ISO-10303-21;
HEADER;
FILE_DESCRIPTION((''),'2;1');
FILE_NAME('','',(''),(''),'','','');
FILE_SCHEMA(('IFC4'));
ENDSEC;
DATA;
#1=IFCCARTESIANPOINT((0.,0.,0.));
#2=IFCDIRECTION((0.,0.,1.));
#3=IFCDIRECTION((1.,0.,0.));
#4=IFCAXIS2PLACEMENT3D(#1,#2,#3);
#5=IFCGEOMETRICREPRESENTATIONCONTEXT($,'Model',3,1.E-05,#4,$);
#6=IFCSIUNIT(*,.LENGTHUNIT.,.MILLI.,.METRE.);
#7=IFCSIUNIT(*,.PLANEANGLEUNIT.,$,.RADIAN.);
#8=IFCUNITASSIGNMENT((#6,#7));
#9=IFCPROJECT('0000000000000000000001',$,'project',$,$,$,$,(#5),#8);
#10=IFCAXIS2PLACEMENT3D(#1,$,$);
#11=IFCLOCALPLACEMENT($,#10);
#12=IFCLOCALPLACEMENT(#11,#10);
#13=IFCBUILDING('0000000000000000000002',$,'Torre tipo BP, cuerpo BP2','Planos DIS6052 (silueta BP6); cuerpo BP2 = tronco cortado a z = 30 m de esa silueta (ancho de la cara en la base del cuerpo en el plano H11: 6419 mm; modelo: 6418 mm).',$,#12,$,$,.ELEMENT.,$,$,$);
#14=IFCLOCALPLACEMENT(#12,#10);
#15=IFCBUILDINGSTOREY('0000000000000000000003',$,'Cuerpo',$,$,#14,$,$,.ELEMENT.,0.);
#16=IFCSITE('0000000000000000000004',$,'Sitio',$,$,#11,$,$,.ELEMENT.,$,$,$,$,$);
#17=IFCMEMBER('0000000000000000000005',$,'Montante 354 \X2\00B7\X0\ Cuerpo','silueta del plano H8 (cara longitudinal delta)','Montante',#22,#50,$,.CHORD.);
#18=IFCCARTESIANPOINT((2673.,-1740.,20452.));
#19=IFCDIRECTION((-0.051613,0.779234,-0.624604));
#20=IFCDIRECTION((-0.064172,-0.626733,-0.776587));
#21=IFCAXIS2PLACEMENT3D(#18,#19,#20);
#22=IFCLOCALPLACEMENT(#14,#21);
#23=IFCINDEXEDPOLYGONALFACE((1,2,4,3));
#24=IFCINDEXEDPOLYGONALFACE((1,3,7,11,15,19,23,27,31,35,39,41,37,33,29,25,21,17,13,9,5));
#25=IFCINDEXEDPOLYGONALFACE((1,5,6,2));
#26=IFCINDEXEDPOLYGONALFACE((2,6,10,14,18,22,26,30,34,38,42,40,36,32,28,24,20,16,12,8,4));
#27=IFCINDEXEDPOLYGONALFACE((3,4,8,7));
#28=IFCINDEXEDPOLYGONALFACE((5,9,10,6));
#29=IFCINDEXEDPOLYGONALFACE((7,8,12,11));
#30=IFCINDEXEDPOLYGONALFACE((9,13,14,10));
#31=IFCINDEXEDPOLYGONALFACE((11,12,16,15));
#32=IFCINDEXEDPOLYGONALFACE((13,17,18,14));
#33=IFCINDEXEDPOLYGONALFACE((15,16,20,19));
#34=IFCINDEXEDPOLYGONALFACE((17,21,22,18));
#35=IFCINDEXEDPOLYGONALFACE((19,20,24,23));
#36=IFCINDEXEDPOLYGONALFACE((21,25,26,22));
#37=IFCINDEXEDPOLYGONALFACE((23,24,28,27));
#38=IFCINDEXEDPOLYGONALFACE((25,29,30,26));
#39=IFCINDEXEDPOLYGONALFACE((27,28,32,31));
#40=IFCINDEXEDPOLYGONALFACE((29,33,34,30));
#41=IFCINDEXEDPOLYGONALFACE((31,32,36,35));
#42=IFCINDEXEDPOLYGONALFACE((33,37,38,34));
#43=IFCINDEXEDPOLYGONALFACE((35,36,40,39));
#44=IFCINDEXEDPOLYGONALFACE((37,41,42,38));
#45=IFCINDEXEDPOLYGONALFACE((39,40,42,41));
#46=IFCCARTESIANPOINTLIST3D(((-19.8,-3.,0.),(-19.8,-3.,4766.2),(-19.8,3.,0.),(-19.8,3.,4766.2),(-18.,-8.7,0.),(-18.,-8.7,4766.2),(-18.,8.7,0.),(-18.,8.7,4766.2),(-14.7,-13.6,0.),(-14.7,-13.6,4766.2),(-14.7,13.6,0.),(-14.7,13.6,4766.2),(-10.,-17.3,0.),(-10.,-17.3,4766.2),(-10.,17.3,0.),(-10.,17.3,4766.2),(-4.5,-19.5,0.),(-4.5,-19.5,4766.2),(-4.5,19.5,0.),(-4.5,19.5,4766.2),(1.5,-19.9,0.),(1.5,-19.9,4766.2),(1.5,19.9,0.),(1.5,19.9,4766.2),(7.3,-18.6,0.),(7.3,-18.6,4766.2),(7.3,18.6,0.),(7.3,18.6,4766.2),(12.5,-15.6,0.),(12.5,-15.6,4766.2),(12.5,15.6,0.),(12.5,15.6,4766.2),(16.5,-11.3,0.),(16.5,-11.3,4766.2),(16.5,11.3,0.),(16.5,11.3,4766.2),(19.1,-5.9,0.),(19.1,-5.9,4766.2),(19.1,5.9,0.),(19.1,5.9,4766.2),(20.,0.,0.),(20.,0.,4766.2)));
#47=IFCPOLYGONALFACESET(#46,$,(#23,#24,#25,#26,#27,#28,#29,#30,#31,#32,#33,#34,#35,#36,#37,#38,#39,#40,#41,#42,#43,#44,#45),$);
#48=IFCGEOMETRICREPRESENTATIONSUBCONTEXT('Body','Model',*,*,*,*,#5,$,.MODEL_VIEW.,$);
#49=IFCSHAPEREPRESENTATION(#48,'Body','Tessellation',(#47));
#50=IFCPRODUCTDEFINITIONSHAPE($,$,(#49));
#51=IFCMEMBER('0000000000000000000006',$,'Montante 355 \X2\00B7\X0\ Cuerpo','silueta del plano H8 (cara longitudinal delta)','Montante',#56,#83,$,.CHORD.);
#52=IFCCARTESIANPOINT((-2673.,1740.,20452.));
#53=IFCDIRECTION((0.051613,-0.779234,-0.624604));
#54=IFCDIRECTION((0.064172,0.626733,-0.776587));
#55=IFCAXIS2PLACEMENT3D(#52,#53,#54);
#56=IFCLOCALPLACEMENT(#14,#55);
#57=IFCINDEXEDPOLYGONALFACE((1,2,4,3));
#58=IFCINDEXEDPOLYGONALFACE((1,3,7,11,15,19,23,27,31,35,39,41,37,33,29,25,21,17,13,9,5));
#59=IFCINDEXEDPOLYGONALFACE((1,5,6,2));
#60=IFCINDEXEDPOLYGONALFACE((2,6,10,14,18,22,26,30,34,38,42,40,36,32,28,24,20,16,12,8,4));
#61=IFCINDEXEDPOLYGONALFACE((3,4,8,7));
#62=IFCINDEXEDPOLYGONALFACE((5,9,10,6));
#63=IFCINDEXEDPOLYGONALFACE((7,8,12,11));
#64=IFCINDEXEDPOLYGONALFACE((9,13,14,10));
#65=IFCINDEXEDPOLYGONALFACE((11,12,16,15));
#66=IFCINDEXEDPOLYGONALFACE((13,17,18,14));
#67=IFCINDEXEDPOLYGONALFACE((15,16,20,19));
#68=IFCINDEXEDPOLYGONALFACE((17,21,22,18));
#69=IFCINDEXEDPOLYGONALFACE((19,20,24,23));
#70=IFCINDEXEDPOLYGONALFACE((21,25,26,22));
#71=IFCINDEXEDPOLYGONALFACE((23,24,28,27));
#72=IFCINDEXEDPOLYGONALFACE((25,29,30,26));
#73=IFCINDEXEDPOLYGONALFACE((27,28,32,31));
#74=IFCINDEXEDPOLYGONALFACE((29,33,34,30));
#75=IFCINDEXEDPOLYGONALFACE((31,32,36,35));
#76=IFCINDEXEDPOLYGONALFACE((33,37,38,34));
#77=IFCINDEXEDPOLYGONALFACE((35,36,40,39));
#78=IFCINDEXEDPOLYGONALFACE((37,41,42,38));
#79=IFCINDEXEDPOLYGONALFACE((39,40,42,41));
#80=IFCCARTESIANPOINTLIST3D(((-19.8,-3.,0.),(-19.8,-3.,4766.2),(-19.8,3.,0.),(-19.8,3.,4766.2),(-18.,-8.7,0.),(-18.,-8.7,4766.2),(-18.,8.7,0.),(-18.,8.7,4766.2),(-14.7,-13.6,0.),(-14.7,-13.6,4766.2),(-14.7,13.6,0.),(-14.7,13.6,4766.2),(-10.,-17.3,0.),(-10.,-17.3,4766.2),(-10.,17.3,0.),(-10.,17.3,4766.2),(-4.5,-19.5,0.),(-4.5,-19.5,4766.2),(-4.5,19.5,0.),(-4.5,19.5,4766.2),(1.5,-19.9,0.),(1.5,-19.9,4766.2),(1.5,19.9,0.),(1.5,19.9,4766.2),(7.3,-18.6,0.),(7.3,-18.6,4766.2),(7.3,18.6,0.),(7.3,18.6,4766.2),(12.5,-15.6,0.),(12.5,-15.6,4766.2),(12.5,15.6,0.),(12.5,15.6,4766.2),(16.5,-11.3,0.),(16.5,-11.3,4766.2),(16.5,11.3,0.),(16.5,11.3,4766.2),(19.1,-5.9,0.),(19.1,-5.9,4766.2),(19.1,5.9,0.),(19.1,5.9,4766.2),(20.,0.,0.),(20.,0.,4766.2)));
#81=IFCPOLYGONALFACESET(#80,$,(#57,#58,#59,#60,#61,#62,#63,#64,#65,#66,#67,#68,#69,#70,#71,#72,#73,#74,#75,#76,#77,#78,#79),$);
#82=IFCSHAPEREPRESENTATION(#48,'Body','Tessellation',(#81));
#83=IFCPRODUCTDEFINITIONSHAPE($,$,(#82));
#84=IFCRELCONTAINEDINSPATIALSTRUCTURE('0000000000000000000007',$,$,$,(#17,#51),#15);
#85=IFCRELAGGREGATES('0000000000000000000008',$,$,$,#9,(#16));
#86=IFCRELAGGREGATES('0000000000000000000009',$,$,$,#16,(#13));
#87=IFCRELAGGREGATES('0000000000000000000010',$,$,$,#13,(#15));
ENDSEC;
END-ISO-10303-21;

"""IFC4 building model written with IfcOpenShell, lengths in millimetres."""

from ifc_helpers import new_model, si_unit, frame, origin, origin_with_axes, place, context, subcontext, project, spatial, circle, extrude, element, save


model = new_model("IFC4")

# Units and contexts
model_context = context("Model", 3, precision=1e-05, world=origin_with_axes())
body_context = subcontext(model_context, "Body", "Model", "MODEL_VIEW")
ifc_project = project(units=[si_unit("LENGTHUNIT", "METRE", prefix="MILLI"), si_unit("PLANEANGLEUNIT", "RADIAN")], contexts=[model_context])

# Site, building, storey
site_placement = place(None, origin())
site = spatial("IfcSite", under=ifc_project, at=site_placement, Name="Sitio", CompositionType="ELEMENT")
building_placement = place(site_placement, origin())
building = spatial("IfcBuilding", under=site, at=building_placement, Name="Torre tipo BP, cuerpo BP2", Description="Planos DIS6052 (silueta BP6); cuerpo BP2 = tronco cortado a z = 30 m de esa silueta (ancho de la cara en la base del cuerpo en el plano H11: 6419 mm; modelo: 6418 mm).", CompositionType="ELEMENT")
storey_placement = place(building_placement, origin())
storey = spatial("IfcBuildingStorey", under=building, at=storey_placement, Name="Cuerpo", CompositionType="ELEMENT", Elevation=0.0)

# Members
for number, where, z_axis, x_axis, name in (
    (1, (2673.0, -1740.0, 20452.0), (-0.051613, 0.779234, -0.624604), (-0.064172, -0.626733, -0.776587), "Montante 354 · Cuerpo"),
    (2, (-2673.0, 1740.0, 20452.0), (0.051613, -0.779234, -0.624604), (0.064172, 0.626733, -0.776587), "Montante 355 · Cuerpo"),
):
    element("IfcMember", number, at=place(storey_placement, frame(where, z_axis=z_axis, x_axis=x_axis)), inside=storey, Name=name, Description="silueta del plano H8 (cara longitudinal delta)", ObjectType="Montante", PredefinedType="CHORD", context=body_context, shape_type="SweptSolid", body=[
        extrude(circle(Radius=20.0), None, (0.0, 0.0, 1.0), 4766.2),
    ])

save(model, "model.ifc")
